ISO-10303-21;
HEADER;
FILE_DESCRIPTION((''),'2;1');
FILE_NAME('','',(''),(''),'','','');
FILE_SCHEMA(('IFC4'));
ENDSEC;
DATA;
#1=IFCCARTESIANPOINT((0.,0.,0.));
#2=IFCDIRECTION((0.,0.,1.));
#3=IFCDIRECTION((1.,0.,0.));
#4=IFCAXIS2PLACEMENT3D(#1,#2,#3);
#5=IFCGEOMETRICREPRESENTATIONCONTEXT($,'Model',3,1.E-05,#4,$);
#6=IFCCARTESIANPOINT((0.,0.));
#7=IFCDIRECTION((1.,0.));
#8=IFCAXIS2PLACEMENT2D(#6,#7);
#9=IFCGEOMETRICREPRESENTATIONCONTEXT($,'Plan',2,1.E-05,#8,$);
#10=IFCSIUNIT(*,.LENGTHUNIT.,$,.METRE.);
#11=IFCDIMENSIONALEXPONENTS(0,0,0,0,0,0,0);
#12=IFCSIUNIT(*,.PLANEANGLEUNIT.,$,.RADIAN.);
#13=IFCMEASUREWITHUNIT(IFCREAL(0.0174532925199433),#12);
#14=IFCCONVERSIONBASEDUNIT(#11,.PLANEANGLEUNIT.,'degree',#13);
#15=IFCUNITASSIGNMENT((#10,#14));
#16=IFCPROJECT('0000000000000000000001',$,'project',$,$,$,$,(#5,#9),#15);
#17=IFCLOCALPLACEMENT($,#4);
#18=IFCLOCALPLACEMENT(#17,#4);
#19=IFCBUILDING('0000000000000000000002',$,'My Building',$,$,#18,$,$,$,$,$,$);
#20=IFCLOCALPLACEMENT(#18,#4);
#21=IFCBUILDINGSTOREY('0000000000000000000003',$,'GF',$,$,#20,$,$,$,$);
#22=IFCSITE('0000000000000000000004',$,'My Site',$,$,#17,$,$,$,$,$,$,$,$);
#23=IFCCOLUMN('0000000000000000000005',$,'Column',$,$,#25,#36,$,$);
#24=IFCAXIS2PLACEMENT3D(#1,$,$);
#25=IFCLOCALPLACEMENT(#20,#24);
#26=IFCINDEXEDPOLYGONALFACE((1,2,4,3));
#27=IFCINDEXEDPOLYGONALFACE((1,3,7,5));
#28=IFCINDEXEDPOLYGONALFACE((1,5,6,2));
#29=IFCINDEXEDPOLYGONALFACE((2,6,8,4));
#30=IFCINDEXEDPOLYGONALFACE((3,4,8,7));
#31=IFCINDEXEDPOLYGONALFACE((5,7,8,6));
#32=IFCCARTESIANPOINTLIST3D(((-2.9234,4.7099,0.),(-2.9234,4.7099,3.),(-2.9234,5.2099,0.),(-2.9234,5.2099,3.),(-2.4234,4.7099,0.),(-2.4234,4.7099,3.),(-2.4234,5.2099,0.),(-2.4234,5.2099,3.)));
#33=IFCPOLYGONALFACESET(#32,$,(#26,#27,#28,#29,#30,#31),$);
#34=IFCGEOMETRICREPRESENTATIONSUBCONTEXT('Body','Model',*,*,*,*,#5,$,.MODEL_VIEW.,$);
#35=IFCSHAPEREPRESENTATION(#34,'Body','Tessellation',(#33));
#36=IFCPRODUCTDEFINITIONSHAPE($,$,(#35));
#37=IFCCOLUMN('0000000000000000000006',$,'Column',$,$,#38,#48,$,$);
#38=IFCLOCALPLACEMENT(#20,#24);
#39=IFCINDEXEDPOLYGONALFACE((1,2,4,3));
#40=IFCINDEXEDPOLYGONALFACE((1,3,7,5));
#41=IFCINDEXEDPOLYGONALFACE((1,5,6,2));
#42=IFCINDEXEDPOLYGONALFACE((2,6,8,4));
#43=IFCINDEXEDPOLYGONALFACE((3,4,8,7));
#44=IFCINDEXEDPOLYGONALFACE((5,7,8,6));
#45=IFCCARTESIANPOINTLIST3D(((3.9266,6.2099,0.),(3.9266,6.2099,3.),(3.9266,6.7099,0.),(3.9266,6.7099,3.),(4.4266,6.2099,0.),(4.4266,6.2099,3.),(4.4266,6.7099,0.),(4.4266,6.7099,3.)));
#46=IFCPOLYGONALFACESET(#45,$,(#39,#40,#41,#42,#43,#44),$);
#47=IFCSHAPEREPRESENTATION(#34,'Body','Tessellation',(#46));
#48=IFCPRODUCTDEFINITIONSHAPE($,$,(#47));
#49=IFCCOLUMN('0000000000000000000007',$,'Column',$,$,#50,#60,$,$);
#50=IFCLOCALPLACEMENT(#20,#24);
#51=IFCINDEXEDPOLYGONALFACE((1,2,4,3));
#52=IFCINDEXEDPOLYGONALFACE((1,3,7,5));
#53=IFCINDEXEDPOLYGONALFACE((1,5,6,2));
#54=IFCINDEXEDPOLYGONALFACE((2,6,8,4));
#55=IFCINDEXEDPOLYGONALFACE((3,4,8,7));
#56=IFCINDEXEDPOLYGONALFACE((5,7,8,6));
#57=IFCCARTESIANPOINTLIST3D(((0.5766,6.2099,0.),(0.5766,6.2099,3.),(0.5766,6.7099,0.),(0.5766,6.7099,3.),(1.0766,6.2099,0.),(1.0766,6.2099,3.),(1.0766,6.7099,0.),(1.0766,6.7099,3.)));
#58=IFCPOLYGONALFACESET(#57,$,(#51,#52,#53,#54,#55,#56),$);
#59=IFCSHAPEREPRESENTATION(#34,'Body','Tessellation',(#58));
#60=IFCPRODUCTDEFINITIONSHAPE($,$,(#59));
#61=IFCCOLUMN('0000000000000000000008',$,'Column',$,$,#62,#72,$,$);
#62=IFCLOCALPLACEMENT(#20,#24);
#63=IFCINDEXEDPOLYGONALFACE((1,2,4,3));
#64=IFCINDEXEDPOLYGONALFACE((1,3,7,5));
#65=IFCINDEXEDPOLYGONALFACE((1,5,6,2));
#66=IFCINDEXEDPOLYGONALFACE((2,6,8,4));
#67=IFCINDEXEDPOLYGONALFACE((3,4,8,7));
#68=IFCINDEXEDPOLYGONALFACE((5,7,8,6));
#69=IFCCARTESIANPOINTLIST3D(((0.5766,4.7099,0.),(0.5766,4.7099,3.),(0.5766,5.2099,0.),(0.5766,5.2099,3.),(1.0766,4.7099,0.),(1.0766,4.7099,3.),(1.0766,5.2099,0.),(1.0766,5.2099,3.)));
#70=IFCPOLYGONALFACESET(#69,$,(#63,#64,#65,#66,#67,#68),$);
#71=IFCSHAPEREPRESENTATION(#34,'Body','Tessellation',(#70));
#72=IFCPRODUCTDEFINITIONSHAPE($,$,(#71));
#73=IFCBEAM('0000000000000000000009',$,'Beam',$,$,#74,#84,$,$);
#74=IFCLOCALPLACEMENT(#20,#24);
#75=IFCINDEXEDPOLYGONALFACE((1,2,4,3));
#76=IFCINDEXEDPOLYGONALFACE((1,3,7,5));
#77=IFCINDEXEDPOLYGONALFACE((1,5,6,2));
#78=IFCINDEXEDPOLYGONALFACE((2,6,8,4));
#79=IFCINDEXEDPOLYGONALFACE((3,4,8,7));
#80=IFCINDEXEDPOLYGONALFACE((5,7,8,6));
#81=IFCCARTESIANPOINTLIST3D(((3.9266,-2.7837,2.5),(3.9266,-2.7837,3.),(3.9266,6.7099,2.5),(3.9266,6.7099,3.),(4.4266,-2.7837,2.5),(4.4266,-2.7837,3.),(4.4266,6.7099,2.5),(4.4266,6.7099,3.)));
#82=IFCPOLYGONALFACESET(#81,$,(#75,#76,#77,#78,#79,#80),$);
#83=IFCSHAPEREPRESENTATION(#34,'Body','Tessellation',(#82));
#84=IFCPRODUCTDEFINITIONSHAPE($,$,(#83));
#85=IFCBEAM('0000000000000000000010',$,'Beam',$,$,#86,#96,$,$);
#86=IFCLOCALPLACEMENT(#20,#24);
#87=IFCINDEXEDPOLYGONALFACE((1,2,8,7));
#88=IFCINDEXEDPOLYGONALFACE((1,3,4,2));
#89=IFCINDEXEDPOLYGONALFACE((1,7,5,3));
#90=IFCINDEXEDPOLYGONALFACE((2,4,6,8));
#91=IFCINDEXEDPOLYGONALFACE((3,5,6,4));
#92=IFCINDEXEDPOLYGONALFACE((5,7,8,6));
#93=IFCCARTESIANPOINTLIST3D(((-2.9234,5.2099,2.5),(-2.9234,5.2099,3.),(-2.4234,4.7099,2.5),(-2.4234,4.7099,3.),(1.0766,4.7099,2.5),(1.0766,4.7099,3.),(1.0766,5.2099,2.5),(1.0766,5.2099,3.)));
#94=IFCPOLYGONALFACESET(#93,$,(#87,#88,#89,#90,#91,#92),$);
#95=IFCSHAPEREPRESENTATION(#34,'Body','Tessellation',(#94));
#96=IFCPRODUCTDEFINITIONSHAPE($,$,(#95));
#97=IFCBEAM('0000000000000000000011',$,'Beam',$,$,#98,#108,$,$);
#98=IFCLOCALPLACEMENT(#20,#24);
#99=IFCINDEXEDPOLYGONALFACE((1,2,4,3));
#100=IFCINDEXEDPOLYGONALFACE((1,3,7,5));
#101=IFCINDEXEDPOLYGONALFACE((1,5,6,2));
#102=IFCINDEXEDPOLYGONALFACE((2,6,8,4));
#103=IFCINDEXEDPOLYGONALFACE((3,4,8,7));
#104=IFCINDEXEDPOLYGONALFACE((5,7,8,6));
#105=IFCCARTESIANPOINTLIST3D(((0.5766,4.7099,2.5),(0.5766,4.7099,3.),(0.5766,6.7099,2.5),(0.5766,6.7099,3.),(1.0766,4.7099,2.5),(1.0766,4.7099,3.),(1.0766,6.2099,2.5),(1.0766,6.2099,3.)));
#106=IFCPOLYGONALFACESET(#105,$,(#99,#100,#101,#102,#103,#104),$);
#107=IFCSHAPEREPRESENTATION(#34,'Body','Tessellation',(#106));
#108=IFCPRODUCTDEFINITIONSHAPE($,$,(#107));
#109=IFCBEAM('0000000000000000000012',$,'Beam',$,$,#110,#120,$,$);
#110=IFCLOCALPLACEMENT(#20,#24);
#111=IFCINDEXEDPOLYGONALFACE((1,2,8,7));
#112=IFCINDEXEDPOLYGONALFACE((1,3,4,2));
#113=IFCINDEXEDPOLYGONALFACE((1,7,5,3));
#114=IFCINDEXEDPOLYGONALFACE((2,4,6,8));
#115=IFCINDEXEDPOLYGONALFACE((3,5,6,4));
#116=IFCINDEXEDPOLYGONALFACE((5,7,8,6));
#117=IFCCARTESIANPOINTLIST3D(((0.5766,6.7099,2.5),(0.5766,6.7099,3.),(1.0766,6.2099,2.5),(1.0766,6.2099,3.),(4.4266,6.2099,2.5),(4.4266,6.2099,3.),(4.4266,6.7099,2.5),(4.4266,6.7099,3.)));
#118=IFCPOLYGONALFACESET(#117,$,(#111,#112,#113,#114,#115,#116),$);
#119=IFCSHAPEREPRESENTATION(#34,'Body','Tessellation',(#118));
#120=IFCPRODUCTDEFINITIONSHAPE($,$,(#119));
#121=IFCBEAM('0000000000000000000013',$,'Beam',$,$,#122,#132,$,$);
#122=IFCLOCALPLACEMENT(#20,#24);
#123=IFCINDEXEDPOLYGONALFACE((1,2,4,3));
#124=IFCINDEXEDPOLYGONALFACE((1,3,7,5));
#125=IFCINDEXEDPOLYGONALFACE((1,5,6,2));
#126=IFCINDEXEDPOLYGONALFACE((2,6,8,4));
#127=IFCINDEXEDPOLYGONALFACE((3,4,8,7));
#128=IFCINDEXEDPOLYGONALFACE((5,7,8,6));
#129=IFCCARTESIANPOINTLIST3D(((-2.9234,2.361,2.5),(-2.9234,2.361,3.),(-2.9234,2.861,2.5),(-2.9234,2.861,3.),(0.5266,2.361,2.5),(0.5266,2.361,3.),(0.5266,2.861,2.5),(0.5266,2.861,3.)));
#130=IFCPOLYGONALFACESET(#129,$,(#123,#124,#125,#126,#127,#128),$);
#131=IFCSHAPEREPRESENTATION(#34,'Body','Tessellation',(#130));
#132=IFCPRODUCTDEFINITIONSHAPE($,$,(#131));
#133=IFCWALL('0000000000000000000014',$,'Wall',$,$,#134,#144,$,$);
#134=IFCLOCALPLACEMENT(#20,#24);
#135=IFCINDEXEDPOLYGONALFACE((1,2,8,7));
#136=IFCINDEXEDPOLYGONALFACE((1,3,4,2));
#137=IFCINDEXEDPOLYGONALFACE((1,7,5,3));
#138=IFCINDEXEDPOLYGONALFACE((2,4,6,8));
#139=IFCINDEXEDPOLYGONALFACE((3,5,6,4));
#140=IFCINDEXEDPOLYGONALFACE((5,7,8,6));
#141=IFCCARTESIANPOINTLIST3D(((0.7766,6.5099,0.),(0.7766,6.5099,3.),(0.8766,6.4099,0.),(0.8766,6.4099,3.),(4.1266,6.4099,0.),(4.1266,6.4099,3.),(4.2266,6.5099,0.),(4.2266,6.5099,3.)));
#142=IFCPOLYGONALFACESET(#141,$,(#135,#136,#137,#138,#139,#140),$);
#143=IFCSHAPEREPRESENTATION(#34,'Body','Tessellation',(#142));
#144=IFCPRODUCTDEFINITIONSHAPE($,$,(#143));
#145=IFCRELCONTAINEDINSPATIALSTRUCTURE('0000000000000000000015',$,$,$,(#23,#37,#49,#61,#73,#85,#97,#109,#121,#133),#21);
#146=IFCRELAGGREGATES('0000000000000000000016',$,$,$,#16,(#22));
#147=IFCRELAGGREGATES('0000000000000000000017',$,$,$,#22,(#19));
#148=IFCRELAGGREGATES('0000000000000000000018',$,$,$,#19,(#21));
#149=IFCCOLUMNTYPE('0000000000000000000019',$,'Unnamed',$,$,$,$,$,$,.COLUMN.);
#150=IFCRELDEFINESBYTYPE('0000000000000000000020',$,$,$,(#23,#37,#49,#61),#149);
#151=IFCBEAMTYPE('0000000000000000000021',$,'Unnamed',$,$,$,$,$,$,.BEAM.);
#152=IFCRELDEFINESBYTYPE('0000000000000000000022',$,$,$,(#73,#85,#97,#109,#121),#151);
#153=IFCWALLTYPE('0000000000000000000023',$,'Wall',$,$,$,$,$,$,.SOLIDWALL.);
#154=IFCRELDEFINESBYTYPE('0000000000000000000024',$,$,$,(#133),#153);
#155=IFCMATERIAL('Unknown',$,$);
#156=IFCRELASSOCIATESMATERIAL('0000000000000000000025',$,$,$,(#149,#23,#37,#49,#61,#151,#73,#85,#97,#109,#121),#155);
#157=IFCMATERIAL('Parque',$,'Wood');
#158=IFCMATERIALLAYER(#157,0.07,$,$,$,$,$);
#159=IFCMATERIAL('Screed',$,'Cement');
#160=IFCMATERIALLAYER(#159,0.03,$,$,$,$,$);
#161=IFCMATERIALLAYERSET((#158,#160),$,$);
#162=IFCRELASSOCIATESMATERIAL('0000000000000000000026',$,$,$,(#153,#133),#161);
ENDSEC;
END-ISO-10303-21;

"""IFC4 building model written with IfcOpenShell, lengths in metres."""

from ifc_helpers import new_model, entity, si_unit, converted_unit, frame, origin_with_axes, origin_2d_with_axis, place, context, subcontext, project, spatial, line, indexed_curve, rectangle, outline, extrude, clip, halfspace, material, layer, layer_set, layer_usage, material_profile, profile_set, profile_usage, type_object, element, save


model = new_model("IFC4")

# Units and contexts
model_context = context("Model", 3, precision=1e-05, world=origin_with_axes())
plan_context = context("Plan", 2, precision=1e-05, world=origin_2d_with_axis())
body_context_1 = subcontext(model_context, "Body", "Model", "MODEL_VIEW")
ifc_project = project(units=[si_unit("LENGTHUNIT", "METRE"), converted_unit("PLANEANGLEUNIT", "degree", entity("IfcReal", 0.0174532925199433), si_unit("PLANEANGLEUNIT", "RADIAN"), dimensions=[0, 0, 0, 0, 0, 0, 0])], contexts=[model_context, plan_context])

# Site, building, storey
site_placement = place(None, origin_with_axes())
site = spatial("IfcSite", under=ifc_project, at=site_placement, Name="My Site")
building_placement = place(site_placement, origin_with_axes())
building = spatial("IfcBuilding", under=site, at=building_placement, Name="My Building")
storey_placement = place(building_placement, origin_with_axes())
storey = spatial("IfcBuildingStorey", under=building, at=storey_placement, Name="GF")

# Columns
ifc_material_1 = material(Name="Unknown")
ifc_material_profile_1 = material_profile(ifc_material_1, rectangle(XDim=0.5, YDim=0.5))
ifc_profile_set_1 = profile_set([ifc_material_profile_1])
ifc_profile_usage_1 = profile_usage(ifc_profile_set_1, cardinal=5)
column_type = type_object("IfcColumnType", Name="Unnamed", PredefinedType="COLUMN", material=ifc_profile_set_1)
column_1_placement = place(storey_placement, frame((-2.6734, 4.9599, 0.0), z_axis=(0.0, 0.0, 1.0), x_axis=(1.0, 0.0, 0.0)))
element("IfcColumn", 1, at=column_1_placement, inside=storey, type_object=column_type, material=ifc_profile_usage_1, Name="Column", context=body_context_1, shape_type="SweptSolid", body=[
    extrude(rectangle(XDim=0.5, YDim=0.5), origin_with_axes(), (0.0, 0.0, 1.0), 3.0),
])
ifc_profile_usage_2 = profile_usage(ifc_profile_set_1, cardinal=5)
column_2_placement = place(storey_placement, frame((4.1766, 6.4599, 0.0), z_axis=(0.0, 0.0, 1.0), x_axis=(1.0, 0.0, 0.0)))
element("IfcColumn", 2, at=column_2_placement, inside=storey, type_object=column_type, material=ifc_profile_usage_2, Name="Column", context=body_context_1, shape_type="SweptSolid", body=[
    extrude(rectangle(XDim=0.5, YDim=0.5), origin_with_axes(), (0.0, 0.0, 1.0), 3.0),
])
ifc_profile_usage_3 = profile_usage(ifc_profile_set_1, cardinal=5)
column_3_placement = place(storey_placement, frame((0.8266, 6.4599, 0.0), z_axis=(0.0, 0.0, 1.0), x_axis=(1.0, 0.0, 0.0)))
element("IfcColumn", 3, at=column_3_placement, inside=storey, type_object=column_type, material=ifc_profile_usage_3, Name="Column", context=body_context_1, shape_type="SweptSolid", body=[
    extrude(rectangle(XDim=0.5, YDim=0.5), origin_with_axes(), (0.0, 0.0, 1.0), 3.0),
])
ifc_profile_usage_4 = profile_usage(ifc_profile_set_1, cardinal=5)
column_4_placement = place(storey_placement, frame((0.8266, 4.9599, 0.0), z_axis=(0.0, 0.0, 1.0), x_axis=(1.0, 0.0, 0.0)))
element("IfcColumn", 4, at=column_4_placement, inside=storey, type_object=column_type, material=ifc_profile_usage_4, Name="Column", context=body_context_1, shape_type="SweptSolid", body=[
    extrude(rectangle(XDim=0.5, YDim=0.5), origin_with_axes(), (0.0, 0.0, 1.0), 3.0),
])

# Beams
ifc_material_profile_2 = material_profile(ifc_material_1, rectangle(XDim=0.5, YDim=0.5))
ifc_profile_set_2 = profile_set([ifc_material_profile_2])
ifc_profile_usage_5 = profile_usage(ifc_profile_set_2, cardinal=7)
beam_type = type_object("IfcBeamType", Name="Unnamed", PredefinedType="BEAM", material=ifc_profile_set_2)
beam_1_placement = place(storey_placement, frame((4.4266, 6.7099, 3.0), z_axis=(0.0, -1.0, 0.0), x_axis=(1.0, 0.0, 0.0)))
element("IfcBeam", 5, at=beam_1_placement, inside=storey, type_object=beam_type, material=ifc_profile_usage_5, Name="Beam", context=body_context_1, shape_type="SweptSolid", body=[
    extrude(rectangle(XDim=0.5, YDim=0.5), frame((-0.25, -0.25, 0.0), z_axis=(0.0, 0.0, 1.0), x_axis=(1.0, 0.0, 0.0)), (0.0, 0.0, 1.0), 9.4936),
])
ifc_profile_usage_6 = profile_usage(ifc_profile_set_2, cardinal=7)
beam_2_placement = place(storey_placement, frame((-2.9234, 5.2099, 3.0), z_axis=(1.0, 0.0, 0.0), x_axis=(0.0, 1.0, 0.0)))
element("IfcBeam", 6, at=beam_2_placement, inside=storey, type_object=beam_type, material=ifc_profile_usage_6, Name="Beam", context=body_context_1, shape_type="Clipping", body=[
    clip(extrude(rectangle(XDim=0.5, YDim=0.5), frame((-0.25, -0.25, 0.0), z_axis=(0.0, 0.0, 1.0), x_axis=(1.0, 0.0, 0.0)), (0.0, 0.0, 1.0), 4.0), halfspace(frame((0.0, -3.0, 0.0), z_axis=(-0.707107, 0.0, -0.707107), x_axis=(0.0, 1.0, 0.0)), False)),
])
ifc_profile_usage_7 = profile_usage(ifc_profile_set_2, cardinal=7)
beam_3_placement = place(storey_placement, frame((0.5766, 4.7099, 3.0), z_axis=(0.0, 1.0, 0.0), x_axis=(-1.0, 0.0, 0.0)))
element("IfcBeam", 7, at=beam_3_placement, inside=storey, type_object=beam_type, material=ifc_profile_usage_7, Name="Beam", context=body_context_1, shape_type="Clipping", body=[
    clip(extrude(rectangle(XDim=0.5, YDim=0.5), frame((-0.25, -0.25, 0.0), z_axis=(0.0, 0.0, 1.0), x_axis=(1.0, 0.0, 0.0)), (0.0, 0.0, 1.0), 2.0), halfspace(frame((0.0, -3.0, 2.0), z_axis=(-0.707107, 0.0, 0.707107), x_axis=(0.0, 1.0, 0.0)), False)),
])
ifc_profile_usage_8 = profile_usage(ifc_profile_set_2, cardinal=7)
beam_4_placement = place(storey_placement, frame((0.5766, 6.7099, 3.0), z_axis=(1.0, -0.000001, 0.0), x_axis=(0.000001, 1.0, 0.0)))
element("IfcBeam", 8, at=beam_4_placement, inside=storey, type_object=beam_type, material=ifc_profile_usage_8, Name="Beam", context=body_context_1, shape_type="Clipping", body=[
    clip(extrude(rectangle(XDim=0.5, YDim=0.5), frame((-0.25, -0.25, 0.0), z_axis=(0.0, 0.0, 1.0), x_axis=(1.0, 0.0, 0.0)), (0.0, 0.0, 1.0), 3.85), halfspace(frame((0.0, -3.0, 0.0), z_axis=(-0.707107, 0.0, -0.707106), x_axis=(0.0, 1.0, 0.0)), False)),
])
ifc_profile_usage_9 = profile_usage(ifc_profile_set_2, cardinal=7)
beam_5_placement = place(storey_placement, frame((-2.9234, 2.861, 3.0), z_axis=(1.0, -0.000001, 0.0), x_axis=(0.000001, 1.0, 0.0)))
element("IfcBeam", 9, at=beam_5_placement, inside=storey, type_object=beam_type, material=ifc_profile_usage_9, Name="Beam", context=body_context_1, shape_type="SweptSolid", body=[
    extrude(rectangle(XDim=0.5, YDim=0.5), frame((-0.25, -0.25, 0.0), z_axis=(0.0, 0.0, 1.0), x_axis=(1.0, 0.0, 0.0)), (0.0, 0.0, 1.0), 3.45),
])

# Wall
ifc_material_2 = material(Name="Parque", Category="Wood")
ifc_layer_1 = layer(ifc_material_2, 0.07)
ifc_material_3 = material(Name="Screed", Category="Cement")
ifc_layer_2 = layer(ifc_material_3, 0.03)
ifc_layer_set_1 = layer_set([ifc_layer_1, ifc_layer_2])
ifc_layer_usage_1 = layer_usage(ifc_layer_set_1, "AXIS2", "POSITIVE", 0.0)
wall_type = type_object("IfcWallType", Name="Wall", PredefinedType="SOLIDWALL", material=ifc_layer_set_1)
wall_1_placement = place(storey_placement, frame((4.2266, 6.5099, 0.0), z_axis=(0.0, 0.0, 1.0), x_axis=(-1.0, 0.0, 0.0)))
element("IfcWall", 10, at=wall_1_placement, inside=storey, type_object=wall_type, material=ifc_layer_usage_1, Name="Wall", context=body_context_1, shape_type="SweptSolid", body=[
    extrude(outline(indexed_curve([(0.0, 0.0), (0.1, 0.1), (3.35, 0.1), (3.45, 0.0)], segments=[line(1, 2, 3, 4, 1)])), origin_with_axes(), (0.0, 0.0, 1.0), 3.0),
])

save(model, "model.ifc")
